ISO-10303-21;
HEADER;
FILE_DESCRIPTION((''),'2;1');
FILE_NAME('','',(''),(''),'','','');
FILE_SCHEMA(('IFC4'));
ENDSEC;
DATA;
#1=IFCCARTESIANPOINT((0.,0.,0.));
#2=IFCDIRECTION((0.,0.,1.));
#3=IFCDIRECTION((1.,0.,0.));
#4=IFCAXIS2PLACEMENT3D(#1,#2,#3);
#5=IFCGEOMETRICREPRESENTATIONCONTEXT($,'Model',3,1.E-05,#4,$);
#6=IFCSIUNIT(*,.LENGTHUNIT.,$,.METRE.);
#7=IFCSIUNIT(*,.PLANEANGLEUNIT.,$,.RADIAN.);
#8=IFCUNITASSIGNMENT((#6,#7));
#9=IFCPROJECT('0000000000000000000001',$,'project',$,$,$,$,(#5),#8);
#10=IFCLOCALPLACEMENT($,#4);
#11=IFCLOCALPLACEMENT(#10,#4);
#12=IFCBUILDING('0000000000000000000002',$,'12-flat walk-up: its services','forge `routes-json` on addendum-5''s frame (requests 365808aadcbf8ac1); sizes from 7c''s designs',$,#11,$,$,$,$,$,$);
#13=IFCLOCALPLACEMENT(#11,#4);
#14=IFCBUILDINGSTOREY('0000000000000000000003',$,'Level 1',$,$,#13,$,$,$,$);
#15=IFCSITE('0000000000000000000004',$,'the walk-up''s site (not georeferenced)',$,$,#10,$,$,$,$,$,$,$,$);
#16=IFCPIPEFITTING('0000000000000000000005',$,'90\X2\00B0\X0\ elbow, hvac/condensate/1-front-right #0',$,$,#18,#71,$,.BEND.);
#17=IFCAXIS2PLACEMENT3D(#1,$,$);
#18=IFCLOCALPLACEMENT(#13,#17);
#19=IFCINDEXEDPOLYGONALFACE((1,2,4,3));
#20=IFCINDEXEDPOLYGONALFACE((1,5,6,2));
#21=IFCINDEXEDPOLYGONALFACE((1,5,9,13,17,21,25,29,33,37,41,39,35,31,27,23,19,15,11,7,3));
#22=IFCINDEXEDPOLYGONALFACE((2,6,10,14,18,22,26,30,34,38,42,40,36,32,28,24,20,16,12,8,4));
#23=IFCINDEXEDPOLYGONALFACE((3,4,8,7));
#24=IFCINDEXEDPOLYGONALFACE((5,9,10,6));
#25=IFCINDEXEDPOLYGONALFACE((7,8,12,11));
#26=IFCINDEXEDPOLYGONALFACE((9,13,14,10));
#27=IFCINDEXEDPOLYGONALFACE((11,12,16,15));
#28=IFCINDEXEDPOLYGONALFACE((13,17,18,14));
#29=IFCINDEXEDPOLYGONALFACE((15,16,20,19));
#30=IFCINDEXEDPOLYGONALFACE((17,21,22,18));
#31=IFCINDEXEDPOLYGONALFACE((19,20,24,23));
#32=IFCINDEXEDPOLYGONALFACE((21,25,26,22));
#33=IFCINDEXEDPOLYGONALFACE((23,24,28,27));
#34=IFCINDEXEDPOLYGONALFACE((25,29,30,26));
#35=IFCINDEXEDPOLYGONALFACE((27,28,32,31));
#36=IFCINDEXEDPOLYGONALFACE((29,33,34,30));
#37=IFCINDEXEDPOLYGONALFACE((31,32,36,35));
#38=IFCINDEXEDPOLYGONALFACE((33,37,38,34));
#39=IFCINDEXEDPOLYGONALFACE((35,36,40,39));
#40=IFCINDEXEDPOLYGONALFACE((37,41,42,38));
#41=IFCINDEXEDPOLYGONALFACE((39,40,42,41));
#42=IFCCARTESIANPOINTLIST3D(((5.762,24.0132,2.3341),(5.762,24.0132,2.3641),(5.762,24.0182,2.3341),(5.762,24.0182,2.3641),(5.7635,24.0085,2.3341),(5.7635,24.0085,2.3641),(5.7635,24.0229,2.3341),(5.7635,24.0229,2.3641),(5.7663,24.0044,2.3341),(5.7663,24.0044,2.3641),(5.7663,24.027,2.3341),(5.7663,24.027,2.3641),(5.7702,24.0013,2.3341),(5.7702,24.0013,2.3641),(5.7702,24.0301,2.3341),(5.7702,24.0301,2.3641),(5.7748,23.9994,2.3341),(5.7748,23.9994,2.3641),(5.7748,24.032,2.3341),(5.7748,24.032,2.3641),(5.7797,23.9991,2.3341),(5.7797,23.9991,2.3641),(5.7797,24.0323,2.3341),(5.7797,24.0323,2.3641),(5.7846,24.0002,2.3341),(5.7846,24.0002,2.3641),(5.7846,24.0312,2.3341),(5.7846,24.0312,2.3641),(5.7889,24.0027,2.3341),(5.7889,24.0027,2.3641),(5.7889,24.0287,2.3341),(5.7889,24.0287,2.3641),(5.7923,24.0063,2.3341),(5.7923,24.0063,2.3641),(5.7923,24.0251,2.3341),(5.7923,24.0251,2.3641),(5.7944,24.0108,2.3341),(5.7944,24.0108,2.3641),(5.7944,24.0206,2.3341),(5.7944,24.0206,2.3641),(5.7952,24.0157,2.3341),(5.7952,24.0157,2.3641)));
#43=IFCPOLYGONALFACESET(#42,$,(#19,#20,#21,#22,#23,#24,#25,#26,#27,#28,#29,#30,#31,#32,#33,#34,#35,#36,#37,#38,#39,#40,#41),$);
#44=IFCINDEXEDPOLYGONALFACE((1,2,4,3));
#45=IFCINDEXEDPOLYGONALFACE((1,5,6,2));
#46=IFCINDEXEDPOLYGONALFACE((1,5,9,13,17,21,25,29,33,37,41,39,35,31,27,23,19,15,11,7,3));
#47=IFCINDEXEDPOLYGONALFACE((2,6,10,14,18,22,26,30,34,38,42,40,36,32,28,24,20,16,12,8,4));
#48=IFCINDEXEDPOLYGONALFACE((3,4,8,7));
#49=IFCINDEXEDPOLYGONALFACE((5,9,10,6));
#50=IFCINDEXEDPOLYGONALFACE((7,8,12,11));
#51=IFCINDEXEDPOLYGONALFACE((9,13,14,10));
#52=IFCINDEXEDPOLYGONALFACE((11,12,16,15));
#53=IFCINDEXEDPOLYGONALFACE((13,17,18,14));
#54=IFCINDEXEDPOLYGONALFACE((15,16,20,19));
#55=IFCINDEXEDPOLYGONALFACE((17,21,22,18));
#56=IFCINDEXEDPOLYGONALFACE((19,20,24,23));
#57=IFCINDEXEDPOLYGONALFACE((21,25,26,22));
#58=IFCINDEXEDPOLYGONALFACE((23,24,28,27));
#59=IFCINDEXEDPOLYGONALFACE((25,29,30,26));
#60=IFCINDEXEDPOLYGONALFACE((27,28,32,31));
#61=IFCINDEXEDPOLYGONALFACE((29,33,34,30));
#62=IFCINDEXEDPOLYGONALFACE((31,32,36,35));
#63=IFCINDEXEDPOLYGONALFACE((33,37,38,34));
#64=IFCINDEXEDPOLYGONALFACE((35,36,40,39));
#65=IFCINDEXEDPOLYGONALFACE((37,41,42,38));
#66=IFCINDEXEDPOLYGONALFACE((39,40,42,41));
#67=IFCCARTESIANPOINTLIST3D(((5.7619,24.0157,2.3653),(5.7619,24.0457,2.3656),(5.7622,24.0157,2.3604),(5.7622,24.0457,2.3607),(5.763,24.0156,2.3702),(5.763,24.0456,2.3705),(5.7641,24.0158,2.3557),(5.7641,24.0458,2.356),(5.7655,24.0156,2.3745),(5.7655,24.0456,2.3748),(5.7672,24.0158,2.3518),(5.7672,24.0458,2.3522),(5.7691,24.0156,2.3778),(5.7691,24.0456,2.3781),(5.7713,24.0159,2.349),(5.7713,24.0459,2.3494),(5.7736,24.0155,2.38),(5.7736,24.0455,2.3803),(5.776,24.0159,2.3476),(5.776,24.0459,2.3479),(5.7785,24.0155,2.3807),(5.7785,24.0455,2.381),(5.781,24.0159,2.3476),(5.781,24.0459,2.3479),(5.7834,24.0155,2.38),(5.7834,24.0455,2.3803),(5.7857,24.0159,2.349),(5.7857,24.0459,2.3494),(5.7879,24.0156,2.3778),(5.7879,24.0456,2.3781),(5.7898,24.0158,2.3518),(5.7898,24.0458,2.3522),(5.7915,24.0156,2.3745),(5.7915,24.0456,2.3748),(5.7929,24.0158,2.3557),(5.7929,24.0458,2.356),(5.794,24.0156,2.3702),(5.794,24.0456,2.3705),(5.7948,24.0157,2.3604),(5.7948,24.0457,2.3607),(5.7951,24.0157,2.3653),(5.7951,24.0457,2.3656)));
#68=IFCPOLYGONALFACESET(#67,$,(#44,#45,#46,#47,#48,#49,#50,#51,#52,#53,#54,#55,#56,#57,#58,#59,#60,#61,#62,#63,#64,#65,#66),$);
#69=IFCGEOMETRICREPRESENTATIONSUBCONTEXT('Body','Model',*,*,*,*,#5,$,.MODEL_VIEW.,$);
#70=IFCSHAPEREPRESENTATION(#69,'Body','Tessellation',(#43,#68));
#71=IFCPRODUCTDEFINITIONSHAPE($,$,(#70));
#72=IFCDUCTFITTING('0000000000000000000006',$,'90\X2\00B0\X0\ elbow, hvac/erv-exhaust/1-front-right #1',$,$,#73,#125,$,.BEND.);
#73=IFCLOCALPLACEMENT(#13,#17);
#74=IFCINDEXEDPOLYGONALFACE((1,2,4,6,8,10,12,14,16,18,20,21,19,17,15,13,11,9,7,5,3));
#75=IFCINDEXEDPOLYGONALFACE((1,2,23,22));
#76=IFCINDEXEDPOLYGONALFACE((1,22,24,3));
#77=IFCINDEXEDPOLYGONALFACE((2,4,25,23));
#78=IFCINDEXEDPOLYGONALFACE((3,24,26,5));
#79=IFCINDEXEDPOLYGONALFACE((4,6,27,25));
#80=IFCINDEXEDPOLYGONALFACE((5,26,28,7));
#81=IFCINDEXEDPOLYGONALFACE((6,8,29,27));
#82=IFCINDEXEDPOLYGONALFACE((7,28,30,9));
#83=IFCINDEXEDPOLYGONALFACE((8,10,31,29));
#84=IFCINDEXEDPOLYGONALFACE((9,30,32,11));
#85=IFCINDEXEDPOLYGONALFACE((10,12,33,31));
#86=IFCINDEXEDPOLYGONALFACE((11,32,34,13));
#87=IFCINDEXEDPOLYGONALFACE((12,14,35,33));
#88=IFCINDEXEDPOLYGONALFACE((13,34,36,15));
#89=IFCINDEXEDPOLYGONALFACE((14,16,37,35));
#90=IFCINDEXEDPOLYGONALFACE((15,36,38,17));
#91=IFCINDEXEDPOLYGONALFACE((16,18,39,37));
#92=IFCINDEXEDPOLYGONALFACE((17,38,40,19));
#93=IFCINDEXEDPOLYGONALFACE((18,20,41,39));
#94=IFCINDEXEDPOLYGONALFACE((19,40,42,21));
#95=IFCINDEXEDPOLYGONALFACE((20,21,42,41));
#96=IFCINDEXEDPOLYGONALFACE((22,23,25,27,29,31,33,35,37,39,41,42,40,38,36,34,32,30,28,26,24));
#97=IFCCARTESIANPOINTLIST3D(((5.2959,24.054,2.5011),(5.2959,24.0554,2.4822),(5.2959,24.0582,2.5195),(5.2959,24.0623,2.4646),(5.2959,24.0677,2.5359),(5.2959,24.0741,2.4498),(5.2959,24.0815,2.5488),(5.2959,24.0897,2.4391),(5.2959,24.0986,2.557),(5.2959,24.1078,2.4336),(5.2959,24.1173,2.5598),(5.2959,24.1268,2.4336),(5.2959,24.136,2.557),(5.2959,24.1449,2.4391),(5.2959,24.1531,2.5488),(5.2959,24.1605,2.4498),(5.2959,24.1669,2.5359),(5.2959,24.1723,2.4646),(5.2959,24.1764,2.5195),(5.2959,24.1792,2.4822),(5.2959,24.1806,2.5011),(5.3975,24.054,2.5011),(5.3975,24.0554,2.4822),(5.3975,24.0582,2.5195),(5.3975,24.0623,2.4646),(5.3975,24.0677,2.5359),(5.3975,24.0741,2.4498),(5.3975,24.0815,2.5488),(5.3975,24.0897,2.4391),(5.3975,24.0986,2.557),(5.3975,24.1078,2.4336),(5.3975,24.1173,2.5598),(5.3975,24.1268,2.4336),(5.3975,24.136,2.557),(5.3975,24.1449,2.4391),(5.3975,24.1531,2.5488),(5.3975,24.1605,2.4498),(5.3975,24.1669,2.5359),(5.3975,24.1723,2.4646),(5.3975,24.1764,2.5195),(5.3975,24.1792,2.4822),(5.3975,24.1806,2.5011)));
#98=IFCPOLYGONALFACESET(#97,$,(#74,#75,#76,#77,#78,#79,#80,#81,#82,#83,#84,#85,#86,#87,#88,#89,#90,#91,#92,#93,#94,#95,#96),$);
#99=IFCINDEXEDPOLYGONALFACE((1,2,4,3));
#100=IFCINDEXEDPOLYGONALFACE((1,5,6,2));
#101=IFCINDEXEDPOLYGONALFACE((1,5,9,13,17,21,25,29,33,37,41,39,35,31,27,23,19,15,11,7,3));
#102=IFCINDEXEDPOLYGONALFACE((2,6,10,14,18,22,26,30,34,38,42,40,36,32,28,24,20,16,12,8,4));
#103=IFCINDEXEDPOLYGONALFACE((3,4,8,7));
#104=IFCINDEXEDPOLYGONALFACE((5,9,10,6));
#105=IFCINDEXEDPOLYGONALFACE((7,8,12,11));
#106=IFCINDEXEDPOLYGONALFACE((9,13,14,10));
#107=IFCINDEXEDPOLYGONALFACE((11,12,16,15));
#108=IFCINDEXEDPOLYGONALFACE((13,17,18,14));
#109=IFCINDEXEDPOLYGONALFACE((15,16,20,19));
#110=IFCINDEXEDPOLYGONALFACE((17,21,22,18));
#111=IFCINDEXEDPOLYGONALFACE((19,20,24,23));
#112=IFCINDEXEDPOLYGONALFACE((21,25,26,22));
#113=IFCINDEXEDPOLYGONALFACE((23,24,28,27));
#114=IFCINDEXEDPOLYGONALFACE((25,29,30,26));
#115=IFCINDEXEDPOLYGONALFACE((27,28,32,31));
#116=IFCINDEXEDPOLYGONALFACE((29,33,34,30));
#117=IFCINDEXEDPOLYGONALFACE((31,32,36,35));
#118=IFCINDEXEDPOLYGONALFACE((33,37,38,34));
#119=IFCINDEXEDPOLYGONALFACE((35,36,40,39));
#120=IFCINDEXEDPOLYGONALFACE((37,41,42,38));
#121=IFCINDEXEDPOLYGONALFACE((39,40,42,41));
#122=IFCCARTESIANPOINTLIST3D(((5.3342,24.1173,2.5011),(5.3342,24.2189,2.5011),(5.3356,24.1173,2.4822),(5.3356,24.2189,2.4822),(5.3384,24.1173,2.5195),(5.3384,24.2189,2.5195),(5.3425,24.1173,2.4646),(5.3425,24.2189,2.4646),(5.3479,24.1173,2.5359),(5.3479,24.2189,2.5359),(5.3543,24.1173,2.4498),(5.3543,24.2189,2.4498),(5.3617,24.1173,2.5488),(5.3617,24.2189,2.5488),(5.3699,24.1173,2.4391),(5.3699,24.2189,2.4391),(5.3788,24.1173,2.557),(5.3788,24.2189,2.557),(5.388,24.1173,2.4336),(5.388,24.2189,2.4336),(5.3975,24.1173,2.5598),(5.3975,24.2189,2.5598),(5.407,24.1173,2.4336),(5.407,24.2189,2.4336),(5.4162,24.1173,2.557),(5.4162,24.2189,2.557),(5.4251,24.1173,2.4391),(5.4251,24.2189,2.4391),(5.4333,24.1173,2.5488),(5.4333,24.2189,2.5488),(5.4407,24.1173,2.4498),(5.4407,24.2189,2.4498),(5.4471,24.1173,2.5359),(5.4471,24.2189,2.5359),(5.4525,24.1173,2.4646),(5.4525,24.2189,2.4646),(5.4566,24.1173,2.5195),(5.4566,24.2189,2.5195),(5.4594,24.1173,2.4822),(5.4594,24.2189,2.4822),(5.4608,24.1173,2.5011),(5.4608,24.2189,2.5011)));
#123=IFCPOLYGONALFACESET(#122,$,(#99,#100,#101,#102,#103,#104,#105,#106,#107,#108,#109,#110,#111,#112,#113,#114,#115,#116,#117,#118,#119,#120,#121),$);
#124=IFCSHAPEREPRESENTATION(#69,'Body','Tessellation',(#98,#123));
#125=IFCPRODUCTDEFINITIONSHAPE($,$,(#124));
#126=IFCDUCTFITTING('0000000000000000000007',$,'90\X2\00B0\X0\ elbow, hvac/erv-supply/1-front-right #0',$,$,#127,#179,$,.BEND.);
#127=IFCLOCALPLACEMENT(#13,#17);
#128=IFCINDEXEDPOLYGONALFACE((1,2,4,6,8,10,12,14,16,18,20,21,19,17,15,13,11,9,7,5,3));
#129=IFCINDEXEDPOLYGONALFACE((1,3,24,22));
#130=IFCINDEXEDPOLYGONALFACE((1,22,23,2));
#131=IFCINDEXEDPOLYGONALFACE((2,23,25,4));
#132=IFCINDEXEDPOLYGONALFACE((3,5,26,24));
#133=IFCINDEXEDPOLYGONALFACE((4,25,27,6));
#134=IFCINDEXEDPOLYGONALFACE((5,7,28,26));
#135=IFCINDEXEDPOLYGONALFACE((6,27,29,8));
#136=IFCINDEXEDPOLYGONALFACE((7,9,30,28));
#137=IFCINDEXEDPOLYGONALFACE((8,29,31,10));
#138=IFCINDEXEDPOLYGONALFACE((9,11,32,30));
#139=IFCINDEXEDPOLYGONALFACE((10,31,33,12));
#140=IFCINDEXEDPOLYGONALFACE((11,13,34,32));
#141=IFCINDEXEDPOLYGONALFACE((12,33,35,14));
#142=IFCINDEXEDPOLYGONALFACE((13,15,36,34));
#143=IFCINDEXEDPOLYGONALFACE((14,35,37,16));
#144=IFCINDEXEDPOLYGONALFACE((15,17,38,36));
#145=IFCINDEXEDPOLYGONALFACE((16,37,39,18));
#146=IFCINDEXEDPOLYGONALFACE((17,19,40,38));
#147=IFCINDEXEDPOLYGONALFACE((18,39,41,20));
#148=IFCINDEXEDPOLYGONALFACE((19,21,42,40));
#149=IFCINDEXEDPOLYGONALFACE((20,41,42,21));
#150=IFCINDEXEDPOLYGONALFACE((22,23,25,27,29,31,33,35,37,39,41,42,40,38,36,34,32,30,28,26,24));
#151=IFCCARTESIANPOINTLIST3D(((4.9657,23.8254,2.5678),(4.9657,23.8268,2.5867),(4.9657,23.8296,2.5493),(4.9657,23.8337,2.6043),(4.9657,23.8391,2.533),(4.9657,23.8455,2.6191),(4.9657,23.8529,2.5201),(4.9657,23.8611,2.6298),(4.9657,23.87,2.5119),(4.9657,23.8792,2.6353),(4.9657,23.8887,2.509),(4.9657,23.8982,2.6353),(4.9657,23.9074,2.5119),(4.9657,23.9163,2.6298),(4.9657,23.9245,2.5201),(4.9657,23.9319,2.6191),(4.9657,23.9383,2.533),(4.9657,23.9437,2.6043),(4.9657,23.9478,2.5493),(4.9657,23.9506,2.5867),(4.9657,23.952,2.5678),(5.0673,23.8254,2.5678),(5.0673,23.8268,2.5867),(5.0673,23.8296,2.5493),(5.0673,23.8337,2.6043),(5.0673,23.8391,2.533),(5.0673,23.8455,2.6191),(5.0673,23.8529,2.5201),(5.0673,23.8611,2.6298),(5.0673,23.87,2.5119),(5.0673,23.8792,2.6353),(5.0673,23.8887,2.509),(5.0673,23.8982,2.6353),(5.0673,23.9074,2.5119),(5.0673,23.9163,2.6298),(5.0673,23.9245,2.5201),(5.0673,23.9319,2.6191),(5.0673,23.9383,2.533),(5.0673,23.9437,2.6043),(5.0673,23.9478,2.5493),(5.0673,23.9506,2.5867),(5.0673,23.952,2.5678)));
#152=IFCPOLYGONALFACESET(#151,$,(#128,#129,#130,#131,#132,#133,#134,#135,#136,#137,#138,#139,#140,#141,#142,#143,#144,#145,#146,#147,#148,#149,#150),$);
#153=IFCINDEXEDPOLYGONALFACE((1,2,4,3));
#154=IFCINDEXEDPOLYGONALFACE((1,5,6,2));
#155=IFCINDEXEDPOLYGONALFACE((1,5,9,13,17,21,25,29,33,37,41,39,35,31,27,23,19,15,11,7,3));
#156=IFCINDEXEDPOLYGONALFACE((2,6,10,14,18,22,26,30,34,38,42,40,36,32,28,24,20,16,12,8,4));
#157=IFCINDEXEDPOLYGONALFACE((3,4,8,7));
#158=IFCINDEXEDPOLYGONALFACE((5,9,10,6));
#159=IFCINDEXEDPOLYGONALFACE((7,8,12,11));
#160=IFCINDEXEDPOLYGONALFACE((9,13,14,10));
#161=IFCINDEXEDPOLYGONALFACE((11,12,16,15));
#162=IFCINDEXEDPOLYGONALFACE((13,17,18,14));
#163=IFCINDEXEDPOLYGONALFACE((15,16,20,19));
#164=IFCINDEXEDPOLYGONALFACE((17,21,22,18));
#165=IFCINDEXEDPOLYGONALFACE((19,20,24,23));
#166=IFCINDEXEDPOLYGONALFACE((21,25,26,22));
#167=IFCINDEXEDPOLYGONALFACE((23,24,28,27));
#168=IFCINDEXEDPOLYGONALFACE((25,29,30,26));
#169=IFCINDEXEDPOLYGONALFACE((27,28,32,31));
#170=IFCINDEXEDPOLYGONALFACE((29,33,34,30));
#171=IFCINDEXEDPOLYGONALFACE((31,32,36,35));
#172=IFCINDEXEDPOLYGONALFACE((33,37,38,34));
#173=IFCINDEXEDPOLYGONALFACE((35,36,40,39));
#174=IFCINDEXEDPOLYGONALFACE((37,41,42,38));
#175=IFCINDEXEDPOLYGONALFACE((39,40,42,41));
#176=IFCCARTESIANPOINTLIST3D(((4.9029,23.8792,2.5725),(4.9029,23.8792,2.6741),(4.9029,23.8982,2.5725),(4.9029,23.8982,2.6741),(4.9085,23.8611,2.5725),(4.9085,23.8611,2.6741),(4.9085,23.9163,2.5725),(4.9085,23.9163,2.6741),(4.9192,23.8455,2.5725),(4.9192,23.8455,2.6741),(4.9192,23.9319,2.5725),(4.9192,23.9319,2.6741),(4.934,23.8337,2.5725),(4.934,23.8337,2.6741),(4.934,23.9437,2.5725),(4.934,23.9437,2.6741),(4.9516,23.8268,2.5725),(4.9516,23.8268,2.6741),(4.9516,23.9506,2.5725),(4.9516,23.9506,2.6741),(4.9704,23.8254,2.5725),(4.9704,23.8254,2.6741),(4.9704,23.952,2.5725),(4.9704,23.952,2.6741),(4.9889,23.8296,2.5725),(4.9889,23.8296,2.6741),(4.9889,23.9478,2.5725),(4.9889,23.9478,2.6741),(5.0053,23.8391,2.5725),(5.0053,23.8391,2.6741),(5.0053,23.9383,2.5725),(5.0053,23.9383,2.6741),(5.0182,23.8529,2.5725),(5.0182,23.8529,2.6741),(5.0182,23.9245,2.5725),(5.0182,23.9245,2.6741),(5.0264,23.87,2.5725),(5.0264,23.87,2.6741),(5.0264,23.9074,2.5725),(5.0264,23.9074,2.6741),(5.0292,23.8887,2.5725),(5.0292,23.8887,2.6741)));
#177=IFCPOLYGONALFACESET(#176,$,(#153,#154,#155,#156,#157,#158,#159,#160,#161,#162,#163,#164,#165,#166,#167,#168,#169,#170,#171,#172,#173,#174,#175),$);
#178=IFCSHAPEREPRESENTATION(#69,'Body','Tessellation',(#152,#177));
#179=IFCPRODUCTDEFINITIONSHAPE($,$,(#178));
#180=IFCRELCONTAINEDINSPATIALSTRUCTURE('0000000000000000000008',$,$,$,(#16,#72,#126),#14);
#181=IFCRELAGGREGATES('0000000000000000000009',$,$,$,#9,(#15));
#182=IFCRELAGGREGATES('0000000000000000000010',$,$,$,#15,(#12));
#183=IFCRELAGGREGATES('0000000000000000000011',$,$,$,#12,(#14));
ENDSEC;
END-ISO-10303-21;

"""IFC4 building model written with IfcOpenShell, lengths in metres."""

from ifc_helpers import new_model, entity, si_unit, frame, origin_with_axes, place, context, subcontext, project, spatial, element, save


model = new_model("IFC4")

# Units and contexts
model_context = context("Model", 3, precision=1e-05, world=origin_with_axes())
body_context = subcontext(model_context, "Body", "Model", "MODEL_VIEW")
ifc_project = project(units=[si_unit("LENGTHUNIT", "METRE"), si_unit("PLANEANGLEUNIT", "RADIAN")], contexts=[model_context])

# Site, building, storey
site_placement = place(None, origin_with_axes())
site = spatial("IfcSite", under=ifc_project, at=site_placement, Name="the walk-up's site (not georeferenced)")
building_placement = place(site_placement, origin_with_axes())
building = spatial("IfcBuilding", under=site, at=building_placement, Name="12-flat walk-up: its services", Description="forge `routes-json` on addendum-5's frame (requests 365808aadcbf8ac1); sizes from 7c's designs")
storey_placement = place(building_placement, origin_with_axes())
storey = spatial("IfcBuildingStorey", under=building, at=storey_placement, Name="Level 1")

# Pipe fitting
pipe_fitting_1_placement = place(storey_placement, frame((5.7785, 24.0157, 2.3341), z_axis=(0.0, 0.0, 1.0), x_axis=(1.0, 0.0, 0.0)))
element("IfcPipeFitting", 1, at=pipe_fitting_1_placement, inside=storey, Name="90° elbow, hvac/condensate/1-front-right #0", PredefinedType="BEND", context=body_context, shape_type="AdvancedSweptSolid", body=[
    entity("IfcSweptDiskSolid", entity("IfcPolyline", [entity("IfcCartesianPoint", [0.0, 0.0, 0.0]), entity("IfcCartesianPoint", [0.0, 0.0, 0.03])]), 0.0167),
    entity("IfcSweptDiskSolid", entity("IfcPolyline", [entity("IfcCartesianPoint", [0.0, 0.0, 0.03]), entity("IfcCartesianPoint", [0.0, 0.03, 0.0303])]), 0.0167),
])

# Duct fittings
duct_fitting_1_placement = place(storey_placement, frame((5.2959, 24.1173, 2.4963), z_axis=(0.0, 0.0, 1.0), x_axis=(1.0, 0.0, 0.0)))
element("IfcDuctFitting", 2, at=duct_fitting_1_placement, inside=storey, Name="90° elbow, hvac/erv-exhaust/1-front-right #1", PredefinedType="BEND", context=body_context, shape_type="AdvancedSweptSolid", body=[
    entity("IfcSweptDiskSolid", entity("IfcPolyline", [entity("IfcCartesianPoint", [0.0, 0.0, 0.0]), entity("IfcCartesianPoint", [0.1016, 0.0, 0.0])]), 0.0635),
    entity("IfcSweptDiskSolid", entity("IfcPolyline", [entity("IfcCartesianPoint", [0.1016, 0.0, 0.0]), entity("IfcCartesianPoint", [0.1016, 0.1016, 0.0])]), 0.0635),
])
duct_fitting_2_placement = place(storey_placement, frame((5.0673, 23.8887, 2.5725), z_axis=(0.0, 0.0, 1.0), x_axis=(1.0, 0.0, 0.0)))
element("IfcDuctFitting", 3, at=duct_fitting_2_placement, inside=storey, Name="90° elbow, hvac/erv-supply/1-front-right #0", PredefinedType="BEND", context=body_context, shape_type="AdvancedSweptSolid", body=[
    entity("IfcSweptDiskSolid", entity("IfcPolyline", [entity("IfcCartesianPoint", [0.0, 0.0, 0.0]), entity("IfcCartesianPoint", [-0.1016, 0.0, 0.0])]), 0.0635),
    entity("IfcSweptDiskSolid", entity("IfcPolyline", [entity("IfcCartesianPoint", [-0.1016, 0.0, 0.0]), entity("IfcCartesianPoint", [-0.1016, 0.0, 0.1016])]), 0.0635),
])

save(model, "model.ifc")
